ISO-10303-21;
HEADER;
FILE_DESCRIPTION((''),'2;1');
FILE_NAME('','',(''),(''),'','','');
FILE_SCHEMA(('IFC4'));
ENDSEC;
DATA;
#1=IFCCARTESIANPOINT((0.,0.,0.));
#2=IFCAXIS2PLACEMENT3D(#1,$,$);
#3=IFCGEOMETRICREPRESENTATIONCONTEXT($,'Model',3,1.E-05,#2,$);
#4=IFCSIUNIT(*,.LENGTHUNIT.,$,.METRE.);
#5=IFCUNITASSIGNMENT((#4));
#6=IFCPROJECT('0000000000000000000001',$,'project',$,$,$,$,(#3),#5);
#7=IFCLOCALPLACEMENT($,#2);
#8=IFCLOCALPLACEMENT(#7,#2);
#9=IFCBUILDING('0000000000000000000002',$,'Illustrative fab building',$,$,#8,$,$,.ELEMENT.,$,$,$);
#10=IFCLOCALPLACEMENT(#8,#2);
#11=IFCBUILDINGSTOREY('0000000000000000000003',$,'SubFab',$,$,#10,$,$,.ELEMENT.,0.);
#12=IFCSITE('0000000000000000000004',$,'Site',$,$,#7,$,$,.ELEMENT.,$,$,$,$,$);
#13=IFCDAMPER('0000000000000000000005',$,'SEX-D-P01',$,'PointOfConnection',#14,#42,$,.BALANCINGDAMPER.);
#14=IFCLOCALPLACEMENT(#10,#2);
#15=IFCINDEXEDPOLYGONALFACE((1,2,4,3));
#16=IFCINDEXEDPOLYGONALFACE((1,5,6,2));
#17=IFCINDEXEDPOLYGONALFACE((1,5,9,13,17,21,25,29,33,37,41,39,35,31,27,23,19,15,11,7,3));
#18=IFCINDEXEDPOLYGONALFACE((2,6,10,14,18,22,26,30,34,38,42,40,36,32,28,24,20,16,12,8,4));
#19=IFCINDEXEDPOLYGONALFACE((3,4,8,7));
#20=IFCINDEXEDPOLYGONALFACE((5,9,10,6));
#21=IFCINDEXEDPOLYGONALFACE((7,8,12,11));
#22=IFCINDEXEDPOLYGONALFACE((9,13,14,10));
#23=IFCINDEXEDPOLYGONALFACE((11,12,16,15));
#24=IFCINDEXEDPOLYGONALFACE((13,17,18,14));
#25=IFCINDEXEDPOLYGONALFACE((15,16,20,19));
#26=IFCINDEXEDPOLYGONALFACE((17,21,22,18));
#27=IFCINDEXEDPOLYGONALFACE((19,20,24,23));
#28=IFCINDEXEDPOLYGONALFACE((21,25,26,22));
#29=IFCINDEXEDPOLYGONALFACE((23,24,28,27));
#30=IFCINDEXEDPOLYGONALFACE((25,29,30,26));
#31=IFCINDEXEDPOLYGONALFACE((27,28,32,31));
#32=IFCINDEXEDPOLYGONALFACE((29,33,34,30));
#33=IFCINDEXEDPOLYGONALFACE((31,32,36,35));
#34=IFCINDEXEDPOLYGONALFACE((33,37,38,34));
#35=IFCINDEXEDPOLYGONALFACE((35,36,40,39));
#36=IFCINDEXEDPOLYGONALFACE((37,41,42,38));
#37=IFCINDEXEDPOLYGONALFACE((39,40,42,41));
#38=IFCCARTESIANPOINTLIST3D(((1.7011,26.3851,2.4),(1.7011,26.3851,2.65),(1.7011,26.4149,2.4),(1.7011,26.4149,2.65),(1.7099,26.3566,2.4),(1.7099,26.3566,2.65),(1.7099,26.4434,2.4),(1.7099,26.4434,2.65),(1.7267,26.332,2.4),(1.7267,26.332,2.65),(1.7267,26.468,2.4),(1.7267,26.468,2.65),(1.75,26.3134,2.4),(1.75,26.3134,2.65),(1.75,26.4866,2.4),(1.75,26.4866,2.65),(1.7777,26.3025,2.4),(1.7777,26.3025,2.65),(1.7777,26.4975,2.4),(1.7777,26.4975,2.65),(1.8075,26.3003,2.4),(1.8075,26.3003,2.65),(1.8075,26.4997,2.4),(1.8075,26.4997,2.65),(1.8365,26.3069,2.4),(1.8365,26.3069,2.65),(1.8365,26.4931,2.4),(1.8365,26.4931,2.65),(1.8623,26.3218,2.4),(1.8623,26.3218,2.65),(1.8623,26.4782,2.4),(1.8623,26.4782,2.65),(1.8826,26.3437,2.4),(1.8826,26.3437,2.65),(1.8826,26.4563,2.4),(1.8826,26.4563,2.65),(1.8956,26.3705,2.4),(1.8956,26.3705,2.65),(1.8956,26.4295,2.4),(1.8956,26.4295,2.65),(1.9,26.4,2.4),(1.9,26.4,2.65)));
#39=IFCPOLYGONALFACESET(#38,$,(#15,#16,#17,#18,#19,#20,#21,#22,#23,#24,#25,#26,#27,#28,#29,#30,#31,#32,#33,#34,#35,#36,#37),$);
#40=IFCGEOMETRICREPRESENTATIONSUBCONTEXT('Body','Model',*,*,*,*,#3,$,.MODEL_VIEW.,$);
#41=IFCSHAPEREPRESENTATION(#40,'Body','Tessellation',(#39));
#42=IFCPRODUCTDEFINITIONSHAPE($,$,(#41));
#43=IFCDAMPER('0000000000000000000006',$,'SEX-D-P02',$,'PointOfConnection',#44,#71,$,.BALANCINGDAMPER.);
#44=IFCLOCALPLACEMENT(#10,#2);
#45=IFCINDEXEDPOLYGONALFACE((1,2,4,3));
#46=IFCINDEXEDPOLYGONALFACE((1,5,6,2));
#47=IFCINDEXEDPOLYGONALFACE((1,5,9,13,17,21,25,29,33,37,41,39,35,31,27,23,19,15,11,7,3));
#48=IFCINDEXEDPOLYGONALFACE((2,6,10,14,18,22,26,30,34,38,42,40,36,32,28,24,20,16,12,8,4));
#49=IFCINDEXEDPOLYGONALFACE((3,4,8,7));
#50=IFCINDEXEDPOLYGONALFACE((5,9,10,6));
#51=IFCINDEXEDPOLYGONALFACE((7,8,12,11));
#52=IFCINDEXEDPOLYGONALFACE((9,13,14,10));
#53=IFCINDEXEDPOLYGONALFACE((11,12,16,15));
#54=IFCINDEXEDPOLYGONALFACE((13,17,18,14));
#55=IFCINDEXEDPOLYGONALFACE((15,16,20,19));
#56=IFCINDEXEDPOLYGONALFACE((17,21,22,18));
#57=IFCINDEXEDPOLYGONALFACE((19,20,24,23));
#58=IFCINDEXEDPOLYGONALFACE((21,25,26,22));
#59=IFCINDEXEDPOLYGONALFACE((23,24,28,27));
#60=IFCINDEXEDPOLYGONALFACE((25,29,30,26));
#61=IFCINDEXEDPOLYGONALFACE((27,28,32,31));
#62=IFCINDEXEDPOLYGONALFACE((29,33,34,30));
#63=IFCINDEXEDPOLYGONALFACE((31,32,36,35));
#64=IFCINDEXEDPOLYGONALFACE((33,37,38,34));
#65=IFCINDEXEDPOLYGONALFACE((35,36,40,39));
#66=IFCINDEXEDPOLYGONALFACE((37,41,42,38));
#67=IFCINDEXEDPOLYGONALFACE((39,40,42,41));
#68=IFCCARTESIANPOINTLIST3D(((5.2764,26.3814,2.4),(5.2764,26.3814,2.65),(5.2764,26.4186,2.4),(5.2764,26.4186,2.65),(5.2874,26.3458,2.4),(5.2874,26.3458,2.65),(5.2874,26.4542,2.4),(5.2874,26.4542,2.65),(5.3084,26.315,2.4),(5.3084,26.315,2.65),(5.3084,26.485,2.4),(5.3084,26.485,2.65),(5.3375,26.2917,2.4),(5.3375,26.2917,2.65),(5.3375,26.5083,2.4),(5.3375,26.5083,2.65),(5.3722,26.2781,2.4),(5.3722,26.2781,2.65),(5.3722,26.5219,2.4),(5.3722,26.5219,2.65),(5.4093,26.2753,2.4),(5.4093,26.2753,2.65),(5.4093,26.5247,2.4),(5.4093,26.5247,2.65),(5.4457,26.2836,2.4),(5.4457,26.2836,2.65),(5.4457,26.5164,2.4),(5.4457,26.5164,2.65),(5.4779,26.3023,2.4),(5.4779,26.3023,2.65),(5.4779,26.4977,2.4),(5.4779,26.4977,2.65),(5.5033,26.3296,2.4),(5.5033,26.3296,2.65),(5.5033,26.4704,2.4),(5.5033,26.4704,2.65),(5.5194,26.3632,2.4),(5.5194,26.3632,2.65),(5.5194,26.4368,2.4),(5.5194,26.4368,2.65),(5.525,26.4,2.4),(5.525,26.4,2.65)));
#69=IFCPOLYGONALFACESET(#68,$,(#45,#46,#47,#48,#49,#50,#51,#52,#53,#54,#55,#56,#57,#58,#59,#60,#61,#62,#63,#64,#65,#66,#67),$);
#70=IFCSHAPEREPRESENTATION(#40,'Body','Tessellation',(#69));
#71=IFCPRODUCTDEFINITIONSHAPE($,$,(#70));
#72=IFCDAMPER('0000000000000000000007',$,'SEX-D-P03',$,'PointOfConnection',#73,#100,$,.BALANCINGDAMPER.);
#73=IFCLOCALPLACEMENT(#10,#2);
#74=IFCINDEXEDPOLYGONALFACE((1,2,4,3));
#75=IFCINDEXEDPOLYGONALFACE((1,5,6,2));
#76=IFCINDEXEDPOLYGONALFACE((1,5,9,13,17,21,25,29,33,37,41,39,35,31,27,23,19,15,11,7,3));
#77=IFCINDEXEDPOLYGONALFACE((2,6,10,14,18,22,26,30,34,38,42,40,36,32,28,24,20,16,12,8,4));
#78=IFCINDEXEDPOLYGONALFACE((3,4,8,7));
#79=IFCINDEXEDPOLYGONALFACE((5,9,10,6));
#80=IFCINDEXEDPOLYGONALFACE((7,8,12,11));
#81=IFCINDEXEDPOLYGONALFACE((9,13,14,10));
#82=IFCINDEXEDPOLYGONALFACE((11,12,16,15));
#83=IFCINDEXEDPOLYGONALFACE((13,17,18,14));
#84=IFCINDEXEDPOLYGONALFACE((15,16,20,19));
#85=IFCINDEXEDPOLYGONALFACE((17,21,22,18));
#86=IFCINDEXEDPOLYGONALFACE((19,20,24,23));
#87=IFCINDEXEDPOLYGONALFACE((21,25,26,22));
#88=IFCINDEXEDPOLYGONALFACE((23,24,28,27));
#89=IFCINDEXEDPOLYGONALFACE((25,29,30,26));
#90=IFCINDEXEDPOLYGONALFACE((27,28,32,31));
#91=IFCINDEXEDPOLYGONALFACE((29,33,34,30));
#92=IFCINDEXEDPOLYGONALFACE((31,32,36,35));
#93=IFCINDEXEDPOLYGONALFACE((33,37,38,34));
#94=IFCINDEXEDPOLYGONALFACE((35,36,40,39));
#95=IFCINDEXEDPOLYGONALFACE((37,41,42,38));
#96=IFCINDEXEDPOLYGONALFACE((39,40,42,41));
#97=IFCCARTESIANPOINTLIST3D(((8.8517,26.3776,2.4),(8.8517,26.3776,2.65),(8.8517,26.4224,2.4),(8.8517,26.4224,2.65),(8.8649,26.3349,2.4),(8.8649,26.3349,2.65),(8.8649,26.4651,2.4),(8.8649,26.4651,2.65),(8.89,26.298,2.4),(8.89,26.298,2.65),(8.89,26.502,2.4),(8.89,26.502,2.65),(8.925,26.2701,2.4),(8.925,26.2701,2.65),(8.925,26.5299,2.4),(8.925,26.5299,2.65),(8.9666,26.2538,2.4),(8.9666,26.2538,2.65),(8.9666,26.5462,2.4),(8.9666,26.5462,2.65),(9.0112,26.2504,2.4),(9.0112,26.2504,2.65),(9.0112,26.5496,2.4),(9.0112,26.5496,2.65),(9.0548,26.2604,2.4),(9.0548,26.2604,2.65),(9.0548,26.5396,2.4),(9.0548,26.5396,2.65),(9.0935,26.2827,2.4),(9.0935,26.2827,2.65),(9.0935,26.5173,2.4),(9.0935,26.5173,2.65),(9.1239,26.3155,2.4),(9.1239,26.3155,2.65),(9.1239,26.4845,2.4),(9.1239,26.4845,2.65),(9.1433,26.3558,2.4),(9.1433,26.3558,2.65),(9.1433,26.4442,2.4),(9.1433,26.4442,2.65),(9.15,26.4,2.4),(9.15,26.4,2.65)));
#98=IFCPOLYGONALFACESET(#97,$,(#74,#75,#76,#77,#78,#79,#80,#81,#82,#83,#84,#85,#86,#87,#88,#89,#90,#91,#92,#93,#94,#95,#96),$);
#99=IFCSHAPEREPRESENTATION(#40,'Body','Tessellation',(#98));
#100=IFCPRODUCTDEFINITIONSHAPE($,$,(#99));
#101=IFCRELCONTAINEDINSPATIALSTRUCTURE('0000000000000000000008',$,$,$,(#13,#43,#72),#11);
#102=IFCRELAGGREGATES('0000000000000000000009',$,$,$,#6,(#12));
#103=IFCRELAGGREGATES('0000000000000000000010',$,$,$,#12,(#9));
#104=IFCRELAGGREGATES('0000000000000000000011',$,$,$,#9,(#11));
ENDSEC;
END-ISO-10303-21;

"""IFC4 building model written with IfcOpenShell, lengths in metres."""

from ifc_helpers import new_model, entity, si_unit, frame, origin, place, context, subcontext, project, spatial, element, save


model = new_model("IFC4")

# Units and contexts
model_context = context("Model", 3, precision=1e-05, world=origin())
body_context = subcontext(model_context, "Body", "Model", "MODEL_VIEW")
ifc_project = project(units=[si_unit("LENGTHUNIT", "METRE")], contexts=[model_context])

# Site, building, storey
site_placement = place(None, origin())
site = spatial("IfcSite", under=ifc_project, at=site_placement, Name="Site", CompositionType="ELEMENT")
building_placement = place(site_placement, origin())
building = spatial("IfcBuilding", under=site, at=building_placement, Name="Illustrative fab building", CompositionType="ELEMENT")
storey_placement = place(building_placement, origin())
storey = spatial("IfcBuildingStorey", under=building, at=storey_placement, Name="SubFab", CompositionType="ELEMENT", Elevation=0.0)

# Dampers
damper_1_placement = place(storey_placement, frame((1.8, 26.4, 2.4)))
element("IfcDamper", 1, at=damper_1_placement, inside=storey, Name="SEX-D-P01", ObjectType="PointOfConnection", PredefinedType="BALANCINGDAMPER", context=body_context, shape_type="AdvancedSweptSolid", body=[
    entity("IfcSweptDiskSolid", entity("IfcPolyline", [entity("IfcCartesianPoint", [0.0, 0.0, 0.0]), entity("IfcCartesianPoint", [0.0, 0.0, 0.25])]), 0.1),
])
damper_2_placement = place(storey_placement, frame((5.4, 26.4, 2.4)))
element("IfcDamper", 2, at=damper_2_placement, inside=storey, Name="SEX-D-P02", ObjectType="PointOfConnection", PredefinedType="BALANCINGDAMPER", context=body_context, shape_type="AdvancedSweptSolid", body=[
    entity("IfcSweptDiskSolid", entity("IfcPolyline", [entity("IfcCartesianPoint", [0.0, 0.0, 0.0]), entity("IfcCartesianPoint", [0.0, 0.0, 0.25])]), 0.125),
])
damper_3_placement = place(storey_placement, frame((9.0, 26.4, 2.4)))
element("IfcDamper", 3, at=damper_3_placement, inside=storey, Name="SEX-D-P03", ObjectType="PointOfConnection", PredefinedType="BALANCINGDAMPER", context=body_context, shape_type="AdvancedSweptSolid", body=[
    entity("IfcSweptDiskSolid", entity("IfcPolyline", [entity("IfcCartesianPoint", [0.0, 0.0, 0.0]), entity("IfcCartesianPoint", [0.0, 0.0, 0.25])]), 0.15),
])

save(model, "model.ifc")
